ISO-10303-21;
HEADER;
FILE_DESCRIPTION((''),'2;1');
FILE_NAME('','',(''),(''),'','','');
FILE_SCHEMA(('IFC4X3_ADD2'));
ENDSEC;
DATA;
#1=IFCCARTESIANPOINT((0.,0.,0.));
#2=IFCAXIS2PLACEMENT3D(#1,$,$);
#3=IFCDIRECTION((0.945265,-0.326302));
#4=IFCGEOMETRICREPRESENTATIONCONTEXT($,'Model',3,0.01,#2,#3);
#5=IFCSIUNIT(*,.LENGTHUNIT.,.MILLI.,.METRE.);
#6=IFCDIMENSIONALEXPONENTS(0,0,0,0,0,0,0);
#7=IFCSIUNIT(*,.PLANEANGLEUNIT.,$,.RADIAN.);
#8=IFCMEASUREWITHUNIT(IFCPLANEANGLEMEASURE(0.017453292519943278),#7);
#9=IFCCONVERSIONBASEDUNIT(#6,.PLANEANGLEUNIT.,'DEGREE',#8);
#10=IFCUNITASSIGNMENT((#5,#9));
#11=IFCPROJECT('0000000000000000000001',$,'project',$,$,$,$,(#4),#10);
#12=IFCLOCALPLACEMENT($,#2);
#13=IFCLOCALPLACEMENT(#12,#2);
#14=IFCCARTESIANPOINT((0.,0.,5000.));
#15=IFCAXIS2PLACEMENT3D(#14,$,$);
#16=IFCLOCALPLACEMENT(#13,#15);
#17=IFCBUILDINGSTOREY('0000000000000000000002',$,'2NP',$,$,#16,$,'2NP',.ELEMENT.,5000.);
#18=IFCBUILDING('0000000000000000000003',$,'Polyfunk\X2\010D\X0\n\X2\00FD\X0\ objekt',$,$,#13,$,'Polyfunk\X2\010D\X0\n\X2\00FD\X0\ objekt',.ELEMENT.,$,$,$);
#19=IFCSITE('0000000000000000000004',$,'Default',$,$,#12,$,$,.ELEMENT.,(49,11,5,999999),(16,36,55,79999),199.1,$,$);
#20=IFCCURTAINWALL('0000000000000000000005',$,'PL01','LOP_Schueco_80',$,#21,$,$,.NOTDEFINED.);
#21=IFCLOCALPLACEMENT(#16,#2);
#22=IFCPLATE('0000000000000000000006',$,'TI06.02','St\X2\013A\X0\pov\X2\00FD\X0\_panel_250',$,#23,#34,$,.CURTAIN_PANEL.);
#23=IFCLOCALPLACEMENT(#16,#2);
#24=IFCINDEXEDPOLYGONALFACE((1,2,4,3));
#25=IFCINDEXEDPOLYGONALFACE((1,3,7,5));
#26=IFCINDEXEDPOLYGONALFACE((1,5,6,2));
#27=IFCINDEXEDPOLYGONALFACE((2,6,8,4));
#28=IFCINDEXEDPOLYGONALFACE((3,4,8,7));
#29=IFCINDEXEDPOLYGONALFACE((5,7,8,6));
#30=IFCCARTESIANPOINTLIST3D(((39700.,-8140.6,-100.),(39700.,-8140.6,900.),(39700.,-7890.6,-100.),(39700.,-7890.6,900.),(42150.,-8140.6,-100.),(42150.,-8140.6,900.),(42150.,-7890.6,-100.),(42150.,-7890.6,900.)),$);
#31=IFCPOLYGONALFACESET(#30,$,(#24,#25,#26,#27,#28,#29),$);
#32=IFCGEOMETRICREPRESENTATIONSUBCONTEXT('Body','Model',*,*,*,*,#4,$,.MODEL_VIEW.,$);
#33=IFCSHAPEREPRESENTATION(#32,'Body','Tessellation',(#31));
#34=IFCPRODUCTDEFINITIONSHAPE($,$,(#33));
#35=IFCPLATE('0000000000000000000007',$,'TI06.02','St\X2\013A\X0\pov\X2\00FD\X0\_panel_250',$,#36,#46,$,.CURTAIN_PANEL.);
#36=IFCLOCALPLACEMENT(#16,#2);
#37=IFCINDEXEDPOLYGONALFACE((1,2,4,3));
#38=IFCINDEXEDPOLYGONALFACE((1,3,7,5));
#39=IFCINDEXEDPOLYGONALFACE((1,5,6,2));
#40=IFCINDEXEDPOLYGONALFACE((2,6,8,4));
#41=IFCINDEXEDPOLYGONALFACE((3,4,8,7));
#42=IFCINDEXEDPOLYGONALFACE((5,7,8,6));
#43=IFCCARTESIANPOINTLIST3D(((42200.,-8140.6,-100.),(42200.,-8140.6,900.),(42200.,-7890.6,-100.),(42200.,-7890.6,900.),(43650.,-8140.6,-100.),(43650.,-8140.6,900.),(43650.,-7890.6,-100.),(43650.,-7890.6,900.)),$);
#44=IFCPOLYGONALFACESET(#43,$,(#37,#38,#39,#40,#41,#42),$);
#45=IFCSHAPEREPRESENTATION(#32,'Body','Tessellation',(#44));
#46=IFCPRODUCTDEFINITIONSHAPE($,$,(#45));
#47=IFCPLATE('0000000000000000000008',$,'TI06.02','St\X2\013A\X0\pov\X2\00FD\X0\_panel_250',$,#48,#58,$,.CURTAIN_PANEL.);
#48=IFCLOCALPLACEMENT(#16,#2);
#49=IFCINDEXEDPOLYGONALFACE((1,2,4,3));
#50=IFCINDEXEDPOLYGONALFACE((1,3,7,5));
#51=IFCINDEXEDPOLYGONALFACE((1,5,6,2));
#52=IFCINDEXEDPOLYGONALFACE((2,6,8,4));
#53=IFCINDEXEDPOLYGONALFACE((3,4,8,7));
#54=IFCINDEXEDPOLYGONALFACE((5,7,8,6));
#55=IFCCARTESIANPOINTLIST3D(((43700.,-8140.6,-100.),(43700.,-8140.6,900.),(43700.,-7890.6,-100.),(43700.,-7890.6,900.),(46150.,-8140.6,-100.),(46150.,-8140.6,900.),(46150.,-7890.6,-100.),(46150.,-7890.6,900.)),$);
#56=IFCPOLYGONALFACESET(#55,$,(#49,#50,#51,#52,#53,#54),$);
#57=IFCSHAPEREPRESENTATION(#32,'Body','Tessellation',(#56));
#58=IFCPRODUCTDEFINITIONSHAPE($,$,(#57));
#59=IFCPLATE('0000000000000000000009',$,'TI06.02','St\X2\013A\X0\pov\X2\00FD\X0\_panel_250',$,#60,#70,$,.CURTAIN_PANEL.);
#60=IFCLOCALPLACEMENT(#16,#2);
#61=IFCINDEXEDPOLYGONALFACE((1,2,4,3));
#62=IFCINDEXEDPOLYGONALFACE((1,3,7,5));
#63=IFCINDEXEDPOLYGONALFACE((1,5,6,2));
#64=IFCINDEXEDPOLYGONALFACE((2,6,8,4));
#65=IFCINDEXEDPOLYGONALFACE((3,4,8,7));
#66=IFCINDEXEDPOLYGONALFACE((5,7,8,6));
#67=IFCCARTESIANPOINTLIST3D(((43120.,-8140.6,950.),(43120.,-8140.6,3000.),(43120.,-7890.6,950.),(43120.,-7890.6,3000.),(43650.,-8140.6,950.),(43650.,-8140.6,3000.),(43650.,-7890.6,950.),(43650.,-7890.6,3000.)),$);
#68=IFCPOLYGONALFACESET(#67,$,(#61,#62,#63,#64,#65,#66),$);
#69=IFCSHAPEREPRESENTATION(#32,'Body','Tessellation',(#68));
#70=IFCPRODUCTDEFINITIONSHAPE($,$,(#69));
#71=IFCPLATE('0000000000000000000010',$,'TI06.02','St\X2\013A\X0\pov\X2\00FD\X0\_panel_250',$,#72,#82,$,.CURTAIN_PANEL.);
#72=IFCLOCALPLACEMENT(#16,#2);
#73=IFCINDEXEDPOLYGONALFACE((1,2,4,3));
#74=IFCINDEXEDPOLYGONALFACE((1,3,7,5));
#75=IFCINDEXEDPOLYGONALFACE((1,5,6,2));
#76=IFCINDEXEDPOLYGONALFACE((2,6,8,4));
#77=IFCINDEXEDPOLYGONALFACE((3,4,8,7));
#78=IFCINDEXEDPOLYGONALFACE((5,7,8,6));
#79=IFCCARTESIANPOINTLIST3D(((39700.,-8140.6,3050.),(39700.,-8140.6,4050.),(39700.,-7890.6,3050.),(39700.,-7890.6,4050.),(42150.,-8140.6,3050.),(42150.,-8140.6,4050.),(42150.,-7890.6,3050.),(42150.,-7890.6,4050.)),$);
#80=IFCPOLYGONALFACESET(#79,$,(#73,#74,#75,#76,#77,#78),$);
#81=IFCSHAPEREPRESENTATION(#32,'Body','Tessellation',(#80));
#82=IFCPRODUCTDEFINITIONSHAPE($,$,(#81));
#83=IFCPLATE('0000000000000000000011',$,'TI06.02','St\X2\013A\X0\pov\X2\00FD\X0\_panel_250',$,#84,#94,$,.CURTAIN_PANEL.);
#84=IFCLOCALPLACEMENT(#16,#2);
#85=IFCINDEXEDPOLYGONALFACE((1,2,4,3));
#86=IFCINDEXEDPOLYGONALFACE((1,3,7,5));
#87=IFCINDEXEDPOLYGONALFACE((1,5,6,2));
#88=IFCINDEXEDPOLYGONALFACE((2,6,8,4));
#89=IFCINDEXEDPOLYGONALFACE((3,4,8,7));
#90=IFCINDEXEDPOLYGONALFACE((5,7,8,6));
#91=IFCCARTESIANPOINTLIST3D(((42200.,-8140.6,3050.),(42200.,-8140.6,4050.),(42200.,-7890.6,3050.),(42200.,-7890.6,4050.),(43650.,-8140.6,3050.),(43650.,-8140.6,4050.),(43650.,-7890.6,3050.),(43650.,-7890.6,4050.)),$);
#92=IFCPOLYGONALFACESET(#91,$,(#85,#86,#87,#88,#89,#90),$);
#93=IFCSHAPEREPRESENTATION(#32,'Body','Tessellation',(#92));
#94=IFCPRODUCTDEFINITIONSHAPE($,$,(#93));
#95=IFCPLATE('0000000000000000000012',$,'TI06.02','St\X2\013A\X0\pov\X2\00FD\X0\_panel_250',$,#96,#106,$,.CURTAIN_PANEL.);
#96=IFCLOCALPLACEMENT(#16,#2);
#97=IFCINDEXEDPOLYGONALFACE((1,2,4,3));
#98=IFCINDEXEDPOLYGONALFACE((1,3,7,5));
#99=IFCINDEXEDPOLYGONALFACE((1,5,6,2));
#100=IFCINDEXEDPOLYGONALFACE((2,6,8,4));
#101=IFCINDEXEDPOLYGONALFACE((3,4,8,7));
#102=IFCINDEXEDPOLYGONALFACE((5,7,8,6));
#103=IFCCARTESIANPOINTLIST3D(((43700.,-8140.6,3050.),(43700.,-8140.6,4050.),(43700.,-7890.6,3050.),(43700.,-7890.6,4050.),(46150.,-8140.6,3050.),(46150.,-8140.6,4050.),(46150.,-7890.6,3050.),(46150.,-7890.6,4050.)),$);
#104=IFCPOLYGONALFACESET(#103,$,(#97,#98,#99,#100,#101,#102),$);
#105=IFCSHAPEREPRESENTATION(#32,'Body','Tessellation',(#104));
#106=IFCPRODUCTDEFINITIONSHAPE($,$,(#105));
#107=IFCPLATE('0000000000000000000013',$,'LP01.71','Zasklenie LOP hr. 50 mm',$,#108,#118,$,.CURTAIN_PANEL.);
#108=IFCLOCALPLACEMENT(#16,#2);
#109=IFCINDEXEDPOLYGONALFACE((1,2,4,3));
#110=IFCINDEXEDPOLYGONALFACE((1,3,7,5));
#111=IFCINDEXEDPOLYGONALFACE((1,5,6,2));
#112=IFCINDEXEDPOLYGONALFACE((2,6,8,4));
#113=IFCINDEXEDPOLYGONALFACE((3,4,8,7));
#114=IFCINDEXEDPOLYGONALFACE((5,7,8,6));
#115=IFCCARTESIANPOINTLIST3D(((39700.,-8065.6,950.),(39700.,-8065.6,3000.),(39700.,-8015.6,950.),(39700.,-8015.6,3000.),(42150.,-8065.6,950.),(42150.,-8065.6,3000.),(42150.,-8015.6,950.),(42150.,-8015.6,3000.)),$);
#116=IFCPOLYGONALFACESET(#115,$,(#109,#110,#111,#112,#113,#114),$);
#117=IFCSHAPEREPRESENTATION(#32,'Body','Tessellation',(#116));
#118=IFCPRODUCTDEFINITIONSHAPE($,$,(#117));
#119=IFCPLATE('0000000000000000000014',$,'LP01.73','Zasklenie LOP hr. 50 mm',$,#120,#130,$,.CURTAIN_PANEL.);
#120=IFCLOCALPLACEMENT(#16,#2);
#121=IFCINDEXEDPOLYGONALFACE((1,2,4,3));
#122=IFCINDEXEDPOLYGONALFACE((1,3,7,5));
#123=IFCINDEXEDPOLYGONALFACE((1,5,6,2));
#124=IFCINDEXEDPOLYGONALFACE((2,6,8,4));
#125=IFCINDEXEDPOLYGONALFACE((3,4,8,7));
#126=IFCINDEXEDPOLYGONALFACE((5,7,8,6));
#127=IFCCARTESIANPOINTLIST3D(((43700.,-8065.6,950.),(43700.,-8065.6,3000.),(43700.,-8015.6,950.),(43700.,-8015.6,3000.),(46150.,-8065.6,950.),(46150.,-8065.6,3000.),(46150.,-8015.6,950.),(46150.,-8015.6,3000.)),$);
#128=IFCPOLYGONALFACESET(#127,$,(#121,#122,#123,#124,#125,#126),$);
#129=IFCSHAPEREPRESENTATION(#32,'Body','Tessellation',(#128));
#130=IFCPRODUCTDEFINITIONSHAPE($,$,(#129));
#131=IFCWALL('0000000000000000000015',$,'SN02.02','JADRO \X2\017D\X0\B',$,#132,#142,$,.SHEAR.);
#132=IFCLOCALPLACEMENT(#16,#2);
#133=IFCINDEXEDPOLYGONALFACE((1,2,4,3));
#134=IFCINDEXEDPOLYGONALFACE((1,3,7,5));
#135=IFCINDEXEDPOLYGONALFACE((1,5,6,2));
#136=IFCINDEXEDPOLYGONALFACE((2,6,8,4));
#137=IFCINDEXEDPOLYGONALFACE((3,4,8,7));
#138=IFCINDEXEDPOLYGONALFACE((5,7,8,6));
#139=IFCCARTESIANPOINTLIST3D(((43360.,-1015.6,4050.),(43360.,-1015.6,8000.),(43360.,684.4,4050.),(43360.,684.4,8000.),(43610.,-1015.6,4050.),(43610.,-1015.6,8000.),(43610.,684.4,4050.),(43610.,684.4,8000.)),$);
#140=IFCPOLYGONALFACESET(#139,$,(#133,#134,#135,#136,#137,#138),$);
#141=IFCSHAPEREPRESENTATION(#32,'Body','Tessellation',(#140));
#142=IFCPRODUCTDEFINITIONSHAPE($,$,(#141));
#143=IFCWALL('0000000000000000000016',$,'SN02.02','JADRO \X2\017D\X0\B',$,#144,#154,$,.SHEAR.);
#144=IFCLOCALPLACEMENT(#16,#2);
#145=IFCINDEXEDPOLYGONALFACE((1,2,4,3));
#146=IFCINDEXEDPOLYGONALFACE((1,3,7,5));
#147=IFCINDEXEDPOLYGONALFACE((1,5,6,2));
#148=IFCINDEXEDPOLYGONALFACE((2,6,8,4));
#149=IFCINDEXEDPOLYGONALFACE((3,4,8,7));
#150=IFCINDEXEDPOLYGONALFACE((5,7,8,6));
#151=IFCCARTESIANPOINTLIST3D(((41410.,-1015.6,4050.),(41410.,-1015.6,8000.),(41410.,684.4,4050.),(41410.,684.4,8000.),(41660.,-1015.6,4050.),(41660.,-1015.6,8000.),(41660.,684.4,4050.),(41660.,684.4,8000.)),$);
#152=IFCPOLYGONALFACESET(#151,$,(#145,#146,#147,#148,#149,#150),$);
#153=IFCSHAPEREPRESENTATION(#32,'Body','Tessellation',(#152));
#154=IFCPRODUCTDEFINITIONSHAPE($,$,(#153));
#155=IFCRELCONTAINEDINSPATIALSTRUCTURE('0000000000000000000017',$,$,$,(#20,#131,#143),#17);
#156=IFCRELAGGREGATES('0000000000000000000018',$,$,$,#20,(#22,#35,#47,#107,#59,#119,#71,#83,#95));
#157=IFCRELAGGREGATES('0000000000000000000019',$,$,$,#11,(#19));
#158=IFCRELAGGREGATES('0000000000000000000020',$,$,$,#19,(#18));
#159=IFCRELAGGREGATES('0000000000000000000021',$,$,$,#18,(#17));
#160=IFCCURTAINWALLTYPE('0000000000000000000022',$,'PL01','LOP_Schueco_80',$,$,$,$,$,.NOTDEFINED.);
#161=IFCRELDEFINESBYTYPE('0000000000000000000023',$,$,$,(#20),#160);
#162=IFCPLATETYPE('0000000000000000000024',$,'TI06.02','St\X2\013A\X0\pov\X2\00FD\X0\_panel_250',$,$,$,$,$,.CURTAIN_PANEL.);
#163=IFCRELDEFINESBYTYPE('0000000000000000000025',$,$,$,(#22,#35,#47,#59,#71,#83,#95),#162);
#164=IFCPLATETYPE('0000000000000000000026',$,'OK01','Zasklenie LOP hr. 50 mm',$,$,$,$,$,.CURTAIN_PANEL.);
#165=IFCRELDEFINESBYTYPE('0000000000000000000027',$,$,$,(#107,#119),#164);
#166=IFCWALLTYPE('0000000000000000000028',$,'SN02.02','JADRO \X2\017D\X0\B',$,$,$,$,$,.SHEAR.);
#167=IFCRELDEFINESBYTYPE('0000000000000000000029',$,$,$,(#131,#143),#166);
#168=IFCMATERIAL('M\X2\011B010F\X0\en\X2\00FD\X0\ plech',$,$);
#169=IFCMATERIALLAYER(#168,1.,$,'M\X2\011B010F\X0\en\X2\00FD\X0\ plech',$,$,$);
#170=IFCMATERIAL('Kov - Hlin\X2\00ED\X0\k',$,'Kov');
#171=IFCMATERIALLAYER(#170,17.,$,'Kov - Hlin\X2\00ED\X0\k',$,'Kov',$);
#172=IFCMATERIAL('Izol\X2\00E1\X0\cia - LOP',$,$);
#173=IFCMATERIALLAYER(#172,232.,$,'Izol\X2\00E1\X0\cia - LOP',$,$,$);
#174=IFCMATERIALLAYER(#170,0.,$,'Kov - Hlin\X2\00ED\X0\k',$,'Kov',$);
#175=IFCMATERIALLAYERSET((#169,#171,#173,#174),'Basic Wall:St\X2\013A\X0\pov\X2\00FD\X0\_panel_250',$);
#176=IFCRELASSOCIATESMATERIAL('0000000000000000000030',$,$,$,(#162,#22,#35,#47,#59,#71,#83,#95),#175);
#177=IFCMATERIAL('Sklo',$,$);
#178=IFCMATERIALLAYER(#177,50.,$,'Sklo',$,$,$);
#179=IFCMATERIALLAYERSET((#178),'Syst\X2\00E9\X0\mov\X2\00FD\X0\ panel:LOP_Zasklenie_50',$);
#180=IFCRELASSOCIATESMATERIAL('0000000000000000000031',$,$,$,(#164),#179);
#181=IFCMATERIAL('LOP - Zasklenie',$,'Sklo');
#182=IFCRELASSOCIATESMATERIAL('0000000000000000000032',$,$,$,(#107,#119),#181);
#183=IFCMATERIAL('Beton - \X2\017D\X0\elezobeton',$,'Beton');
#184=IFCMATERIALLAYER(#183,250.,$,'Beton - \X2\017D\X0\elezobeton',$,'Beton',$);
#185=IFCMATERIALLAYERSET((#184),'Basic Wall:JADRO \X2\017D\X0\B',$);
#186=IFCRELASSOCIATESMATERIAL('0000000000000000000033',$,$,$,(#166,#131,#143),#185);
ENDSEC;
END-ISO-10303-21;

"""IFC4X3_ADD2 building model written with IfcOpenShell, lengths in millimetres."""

from ifc_helpers import new_model, entity, si_unit, converted_unit, direction, frame, frame_2d, origin, origin_2d_with_axis, place, context, subcontext, project, spatial, polyline, rectangle, extrude, clip, bounded_halfspace, source, transform, mapped, material, layer, layer_set, layer_usage, type_object, type_shapes, element, aggregate, save


model = new_model("IFC4X3_ADD2")

# Units and contexts
model_context = context("Model", 3, precision=0.01, world=origin(), true_north=direction((0.945265, -0.326302)))
body_context = subcontext(model_context, "Body", "Model", "MODEL_VIEW")
ifc_project = project(units=[si_unit("LENGTHUNIT", "METRE", prefix="MILLI"), converted_unit("PLANEANGLEUNIT", "DEGREE", entity("IfcPlaneAngleMeasure", 0.017453292519943278), si_unit("PLANEANGLEUNIT", "RADIAN"), dimensions=[0, 0, 0, 0, 0, 0, 0])], contexts=[model_context])

# Site, building, storey
site_placement = place(None, origin())
site = spatial("IfcSite", under=ifc_project, at=site_placement, Name="Default", CompositionType="ELEMENT", RefLatitude=(49, 11, 5, 999999), RefLongitude=(16, 36, 55, 79999), RefElevation=199.1)
building_placement = place(site_placement, origin())
building = spatial("IfcBuilding", under=site, at=building_placement, Name="Polyfunkčný objekt", LongName="Polyfunkčný objekt", CompositionType="ELEMENT")
storey_placement = place(building_placement, frame((0.0, 0.0, 5000.0)))
storey = spatial("IfcBuildingStorey", under=building, at=storey_placement, Name="2NP", LongName="2NP", CompositionType="ELEMENT", Elevation=5000.0)

# Curtain wall, plates
curtain_wall_type = type_object("IfcCurtainWallType", Name="PL01", Description="LOP_Schueco_80", PredefinedType="NOTDEFINED")
curtain_wall_placement = place(storey_placement, frame((0.0, 0.0, -5000.0)))
curtain_wall = element("IfcCurtainWall", 1, at=curtain_wall_placement, inside=storey, type_object=curtain_wall_type, Name="PL01", Description="LOP_Schueco_80", PredefinedType="NOTDEFINED")
ifc_material_1 = material(Name="Měďený plech")
ifc_layer_1 = layer(ifc_material_1, 1.0, Name="Měďený plech")
ifc_material_2 = material(Name="Kov - Hliník", Category="Kov")
ifc_layer_2 = layer(ifc_material_2, 17.0, Name="Kov - Hliník", Category="Kov")
ifc_material_3 = material(Name="Izolácia - LOP")
ifc_layer_3 = layer(ifc_material_3, 232.0, Name="Izolácia - LOP")
ifc_layer_4 = layer(ifc_material_2, 0.0, Name="Kov - Hliník", Category="Kov")
ifc_layer_set_1 = layer_set([ifc_layer_1, ifc_layer_2, ifc_layer_3, ifc_layer_4], Name="Basic Wall:Stĺpový_panel_250")
ifc_layer_usage_1 = layer_usage(ifc_layer_set_1, "AXIS2", "POSITIVE", -125.0)
plate_type_1 = type_object("IfcPlateType", Name="TI06.02", Description="Stĺpový_panel_250", PredefinedType="CURTAIN_PANEL", material=ifc_layer_set_1)
plate_1_placement = place(storey_placement, frame((39700.0, -8015.6, -100.0)))
plate_1 = element("IfcPlate", 2, at=plate_1_placement, type_object=plate_type_1, material=ifc_layer_usage_1, Name="TI06.02", Description="Stĺpový_panel_250", PredefinedType="CURTAIN_PANEL", context=body_context, shape_type="SweptSolid", body=[
    extrude(rectangle(XDim=250.0, YDim=2450.0, at=frame_2d((0.0, 0.0), x_axis=(1.0, 0.0))), frame((1225.0, 0.0, 0.0), z_axis=(0.0, 0.0, 1.0), x_axis=(0.0, 1.0, 0.0)), (0.0, 0.0, 1.0), 1000.0),
])
ifc_layer_usage_2 = layer_usage(ifc_layer_set_1, "AXIS2", "POSITIVE", -125.0)
plate_2_placement = place(storey_placement, frame((42200.0, -8015.6, -100.0)))
plate_2 = element("IfcPlate", 3, at=plate_2_placement, type_object=plate_type_1, material=ifc_layer_usage_2, Name="TI06.02", Description="Stĺpový_panel_250", PredefinedType="CURTAIN_PANEL", context=body_context, shape_type="SweptSolid", body=[
    extrude(rectangle(XDim=250.0, YDim=1450.0, at=frame_2d((0.0, 0.0), x_axis=(1.0, 0.0))), frame((725.0, 0.0, 0.0), z_axis=(0.0, 0.0, 1.0), x_axis=(0.0, 1.0, 0.0)), (0.0, 0.0, 1.0), 1000.0),
])
ifc_layer_usage_3 = layer_usage(ifc_layer_set_1, "AXIS2", "POSITIVE", -125.0)
plate_3_placement = place(storey_placement, frame((43700.0, -8015.6, -100.0)))
plate_3 = element("IfcPlate", 4, at=plate_3_placement, type_object=plate_type_1, material=ifc_layer_usage_3, Name="TI06.02", Description="Stĺpový_panel_250", PredefinedType="CURTAIN_PANEL", context=body_context, shape_type="SweptSolid", body=[
    extrude(rectangle(XDim=250.0, YDim=2450.0, at=frame_2d((0.0, 0.0), x_axis=(1.0, 0.0))), frame((1225.0, 0.0, 0.0), z_axis=(0.0, 0.0, 1.0), x_axis=(0.0, 1.0, 0.0)), (0.0, 0.0, 1.0), 1000.0),
])
ifc_layer_usage_4 = layer_usage(ifc_layer_set_1, "AXIS2", "POSITIVE", -125.0)
plate_4_placement = place(storey_placement, frame((43120.0, -8015.6, 950.0)))
plate_4 = element("IfcPlate", 5, at=plate_4_placement, type_object=plate_type_1, material=ifc_layer_usage_4, Name="TI06.02", Description="Stĺpový_panel_250", PredefinedType="CURTAIN_PANEL", context=body_context, shape_type="SweptSolid", body=[
    extrude(rectangle(XDim=250.0, YDim=530.0, at=frame_2d((0.0, 0.0), x_axis=(1.0, 0.0))), frame((265.0, 0.0, 0.0), z_axis=(0.0, 0.0, 1.0), x_axis=(0.0, 1.0, 0.0)), (0.0, 0.0, 1.0), 2050.0),
])
ifc_layer_usage_5 = layer_usage(ifc_layer_set_1, "AXIS2", "POSITIVE", -125.0)
plate_5_placement = place(storey_placement, frame((39700.0, -8015.6, 3050.0)))
plate_5 = element("IfcPlate", 6, at=plate_5_placement, type_object=plate_type_1, material=ifc_layer_usage_5, Name="TI06.02", Description="Stĺpový_panel_250", PredefinedType="CURTAIN_PANEL", context=body_context, shape_type="SweptSolid", body=[
    extrude(rectangle(XDim=250.0, YDim=2450.0, at=frame_2d((0.0, 0.0), x_axis=(1.0, 0.0))), frame((1225.0, 0.0, 0.0), z_axis=(0.0, 0.0, 1.0), x_axis=(0.0, 1.0, 0.0)), (0.0, 0.0, 1.0), 1000.0),
])
ifc_layer_usage_6 = layer_usage(ifc_layer_set_1, "AXIS2", "POSITIVE", -125.0)
plate_6_placement = place(storey_placement, frame((42200.0, -8015.6, 3050.0)))
plate_6 = element("IfcPlate", 7, at=plate_6_placement, type_object=plate_type_1, material=ifc_layer_usage_6, Name="TI06.02", Description="Stĺpový_panel_250", PredefinedType="CURTAIN_PANEL", context=body_context, shape_type="SweptSolid", body=[
    extrude(rectangle(XDim=250.0, YDim=1450.0, at=frame_2d((0.0, 0.0), x_axis=(1.0, 0.0))), frame((725.0, 0.0, 0.0), z_axis=(0.0, 0.0, 1.0), x_axis=(0.0, 1.0, 0.0)), (0.0, 0.0, 1.0), 1000.0),
])
ifc_layer_usage_7 = layer_usage(ifc_layer_set_1, "AXIS2", "POSITIVE", -125.0)
plate_7_placement = place(storey_placement, frame((43700.0, -8015.6, 3050.0)))
plate_7 = element("IfcPlate", 8, at=plate_7_placement, type_object=plate_type_1, material=ifc_layer_usage_7, Name="TI06.02", Description="Stĺpový_panel_250", PredefinedType="CURTAIN_PANEL", context=body_context, shape_type="SweptSolid", body=[
    extrude(rectangle(XDim=250.0, YDim=2450.0, at=frame_2d((0.0, 0.0), x_axis=(1.0, 0.0))), frame((1225.0, 0.0, 0.0), z_axis=(0.0, 0.0, 1.0), x_axis=(0.0, 1.0, 0.0)), (0.0, 0.0, 1.0), 1000.0),
])
ifc_material_4 = material(Name="LOP - Zasklenie", Category="Sklo")
ifc_material_5 = material(Name="Sklo")
ifc_layer_5 = layer(ifc_material_5, 50.0, Name="Sklo")
ifc_layer_set_2 = layer_set([ifc_layer_5], Name="Systémový panel:LOP_Zasklenie_50")
plate_type_2 = type_object("IfcPlateType", Name="OK01", Description="Zasklenie LOP hr. 50 mm", PredefinedType="CURTAIN_PANEL", material=ifc_layer_set_2)
shared_shape_1 = source(origin(), body_context, "Body", "SweptSolid", [
    extrude(rectangle(XDim=50.0, YDim=2450.0, at=origin_2d_with_axis()), frame((0.0, -25.0, 0.0), z_axis=(0.0, 0.0, 1.0), x_axis=(0.0, 1.0, 0.0)), (0.0, 0.0, 1.0), 2050.0),
])
type_shapes(plate_type_2, [shared_shape_1])
plate_8_placement = place(curtain_wall_placement, frame((40925.0, -8015.6, 5950.0)))
plate_8 = element("IfcPlate", 9, at=plate_8_placement, type_object=plate_type_2, material=ifc_material_4, Name="LP01.71", Description="Zasklenie LOP hr. 50 mm", PredefinedType="CURTAIN_PANEL", context=body_context, shape_type="MappedRepresentation", body=[
    mapped(shared_shape_1, transform((0.0, 0.0, 0.0), scale=1.0)),
])
plate_9_placement = place(curtain_wall_placement, frame((44925.0, -8015.6, 5950.0)))
plate_9 = element("IfcPlate", 10, at=plate_9_placement, type_object=plate_type_2, material=ifc_material_4, Name="LP01.73", Description="Zasklenie LOP hr. 50 mm", PredefinedType="CURTAIN_PANEL", context=body_context, shape_type="MappedRepresentation", body=[
    mapped(shared_shape_1, transform((0.0, 0.0, 0.0), scale=1.0)),
])

# Walls
ifc_material_6 = material(Name="Beton - Železobeton", Category="Beton")
ifc_layer_6 = layer(ifc_material_6, 250.0, Name="Beton - Železobeton", Category="Beton")
ifc_layer_set_3 = layer_set([ifc_layer_6], Name="Basic Wall:JADRO ŽB")
wall_type = type_object("IfcWallType", Name="SN02.02", Description="JADRO ŽB", PredefinedType="SHEAR", material=ifc_layer_set_3)
wall_1_placement = place(storey_placement, frame((43485.0, 684.4, 4050.0), z_axis=(0.0, 0.0, 1.0), x_axis=(0.0, -1.0, 0.0)))
element("IfcWall", 11, at=wall_1_placement, inside=storey, type_object=wall_type, material=ifc_layer_set_3, Name="SN02.02", Description="JADRO ŽB", PredefinedType="SHEAR", context=body_context, shape_type="Clipping", body=[
    clip(clip(extrude(rectangle(XDim=1700.0, YDim=250.0, at=frame_2d((850.0, 0.0), x_axis=(-1.0, 0.0))), origin(), (0.0, 0.0, 1.0), 3950.0), bounded_halfspace(frame((1700.0, -125.0, 0.0), z_axis=(0.0, 0.0, 1.0), x_axis=(0.0, -1.0, 0.0)), True, frame((1700.0, -125.0, 0.0)), polyline([(0.0, 0.0), (0.0, 250.0), (-1700.0, 250.0), (-1700.0, 0.0), (0.0, 0.0)]))), bounded_halfspace(frame((0.0, -125.0, 3950.0), z_axis=(0.0, 0.0, -1.0), x_axis=(0.0, 1.0, 0.0)), True, frame((0.0, -125.0, 3950.0)), polyline([(0.0, 0.0), (1700.0, 0.0), (1700.0, 250.0), (0.0, 250.0), (0.0, 0.0)]))),
])
wall_2_placement = place(storey_placement, frame((41535.0, 684.4, 4050.0), z_axis=(0.0, 0.0, 1.0), x_axis=(0.0, -1.0, 0.0)))
element("IfcWall", 12, at=wall_2_placement, inside=storey, type_object=wall_type, material=ifc_layer_set_3, Name="SN02.02", Description="JADRO ŽB", PredefinedType="SHEAR", context=body_context, shape_type="Clipping", body=[
    clip(clip(extrude(rectangle(XDim=1700.0, YDim=250.0, at=frame_2d((850.0, 0.0), x_axis=(-1.0, 0.0))), origin(), (0.0, 0.0, 1.0), 3950.0), bounded_halfspace(frame((1700.0, -125.0, 0.0), z_axis=(0.0, 0.0, 1.0), x_axis=(0.0, -1.0, 0.0)), True, frame((1700.0, -125.0, 0.0)), polyline([(0.0, 0.0), (0.0, 250.0), (-1700.0, 250.0), (-1700.0, 0.0), (0.0, 0.0)]))), bounded_halfspace(frame((0.0, -125.0, 3950.0), z_axis=(0.0, 0.0, -1.0), x_axis=(0.0, 1.0, 0.0)), True, frame((0.0, -125.0, 3950.0)), polyline([(0.0, 0.0), (1700.0, 0.0), (1700.0, 250.0), (0.0, 250.0), (0.0, 0.0)]))),
])

aggregate(curtain_wall, [plate_1, plate_2, plate_3, plate_8, plate_4, plate_9, plate_5, plate_6, plate_7])

save(model, "model.ifc")
